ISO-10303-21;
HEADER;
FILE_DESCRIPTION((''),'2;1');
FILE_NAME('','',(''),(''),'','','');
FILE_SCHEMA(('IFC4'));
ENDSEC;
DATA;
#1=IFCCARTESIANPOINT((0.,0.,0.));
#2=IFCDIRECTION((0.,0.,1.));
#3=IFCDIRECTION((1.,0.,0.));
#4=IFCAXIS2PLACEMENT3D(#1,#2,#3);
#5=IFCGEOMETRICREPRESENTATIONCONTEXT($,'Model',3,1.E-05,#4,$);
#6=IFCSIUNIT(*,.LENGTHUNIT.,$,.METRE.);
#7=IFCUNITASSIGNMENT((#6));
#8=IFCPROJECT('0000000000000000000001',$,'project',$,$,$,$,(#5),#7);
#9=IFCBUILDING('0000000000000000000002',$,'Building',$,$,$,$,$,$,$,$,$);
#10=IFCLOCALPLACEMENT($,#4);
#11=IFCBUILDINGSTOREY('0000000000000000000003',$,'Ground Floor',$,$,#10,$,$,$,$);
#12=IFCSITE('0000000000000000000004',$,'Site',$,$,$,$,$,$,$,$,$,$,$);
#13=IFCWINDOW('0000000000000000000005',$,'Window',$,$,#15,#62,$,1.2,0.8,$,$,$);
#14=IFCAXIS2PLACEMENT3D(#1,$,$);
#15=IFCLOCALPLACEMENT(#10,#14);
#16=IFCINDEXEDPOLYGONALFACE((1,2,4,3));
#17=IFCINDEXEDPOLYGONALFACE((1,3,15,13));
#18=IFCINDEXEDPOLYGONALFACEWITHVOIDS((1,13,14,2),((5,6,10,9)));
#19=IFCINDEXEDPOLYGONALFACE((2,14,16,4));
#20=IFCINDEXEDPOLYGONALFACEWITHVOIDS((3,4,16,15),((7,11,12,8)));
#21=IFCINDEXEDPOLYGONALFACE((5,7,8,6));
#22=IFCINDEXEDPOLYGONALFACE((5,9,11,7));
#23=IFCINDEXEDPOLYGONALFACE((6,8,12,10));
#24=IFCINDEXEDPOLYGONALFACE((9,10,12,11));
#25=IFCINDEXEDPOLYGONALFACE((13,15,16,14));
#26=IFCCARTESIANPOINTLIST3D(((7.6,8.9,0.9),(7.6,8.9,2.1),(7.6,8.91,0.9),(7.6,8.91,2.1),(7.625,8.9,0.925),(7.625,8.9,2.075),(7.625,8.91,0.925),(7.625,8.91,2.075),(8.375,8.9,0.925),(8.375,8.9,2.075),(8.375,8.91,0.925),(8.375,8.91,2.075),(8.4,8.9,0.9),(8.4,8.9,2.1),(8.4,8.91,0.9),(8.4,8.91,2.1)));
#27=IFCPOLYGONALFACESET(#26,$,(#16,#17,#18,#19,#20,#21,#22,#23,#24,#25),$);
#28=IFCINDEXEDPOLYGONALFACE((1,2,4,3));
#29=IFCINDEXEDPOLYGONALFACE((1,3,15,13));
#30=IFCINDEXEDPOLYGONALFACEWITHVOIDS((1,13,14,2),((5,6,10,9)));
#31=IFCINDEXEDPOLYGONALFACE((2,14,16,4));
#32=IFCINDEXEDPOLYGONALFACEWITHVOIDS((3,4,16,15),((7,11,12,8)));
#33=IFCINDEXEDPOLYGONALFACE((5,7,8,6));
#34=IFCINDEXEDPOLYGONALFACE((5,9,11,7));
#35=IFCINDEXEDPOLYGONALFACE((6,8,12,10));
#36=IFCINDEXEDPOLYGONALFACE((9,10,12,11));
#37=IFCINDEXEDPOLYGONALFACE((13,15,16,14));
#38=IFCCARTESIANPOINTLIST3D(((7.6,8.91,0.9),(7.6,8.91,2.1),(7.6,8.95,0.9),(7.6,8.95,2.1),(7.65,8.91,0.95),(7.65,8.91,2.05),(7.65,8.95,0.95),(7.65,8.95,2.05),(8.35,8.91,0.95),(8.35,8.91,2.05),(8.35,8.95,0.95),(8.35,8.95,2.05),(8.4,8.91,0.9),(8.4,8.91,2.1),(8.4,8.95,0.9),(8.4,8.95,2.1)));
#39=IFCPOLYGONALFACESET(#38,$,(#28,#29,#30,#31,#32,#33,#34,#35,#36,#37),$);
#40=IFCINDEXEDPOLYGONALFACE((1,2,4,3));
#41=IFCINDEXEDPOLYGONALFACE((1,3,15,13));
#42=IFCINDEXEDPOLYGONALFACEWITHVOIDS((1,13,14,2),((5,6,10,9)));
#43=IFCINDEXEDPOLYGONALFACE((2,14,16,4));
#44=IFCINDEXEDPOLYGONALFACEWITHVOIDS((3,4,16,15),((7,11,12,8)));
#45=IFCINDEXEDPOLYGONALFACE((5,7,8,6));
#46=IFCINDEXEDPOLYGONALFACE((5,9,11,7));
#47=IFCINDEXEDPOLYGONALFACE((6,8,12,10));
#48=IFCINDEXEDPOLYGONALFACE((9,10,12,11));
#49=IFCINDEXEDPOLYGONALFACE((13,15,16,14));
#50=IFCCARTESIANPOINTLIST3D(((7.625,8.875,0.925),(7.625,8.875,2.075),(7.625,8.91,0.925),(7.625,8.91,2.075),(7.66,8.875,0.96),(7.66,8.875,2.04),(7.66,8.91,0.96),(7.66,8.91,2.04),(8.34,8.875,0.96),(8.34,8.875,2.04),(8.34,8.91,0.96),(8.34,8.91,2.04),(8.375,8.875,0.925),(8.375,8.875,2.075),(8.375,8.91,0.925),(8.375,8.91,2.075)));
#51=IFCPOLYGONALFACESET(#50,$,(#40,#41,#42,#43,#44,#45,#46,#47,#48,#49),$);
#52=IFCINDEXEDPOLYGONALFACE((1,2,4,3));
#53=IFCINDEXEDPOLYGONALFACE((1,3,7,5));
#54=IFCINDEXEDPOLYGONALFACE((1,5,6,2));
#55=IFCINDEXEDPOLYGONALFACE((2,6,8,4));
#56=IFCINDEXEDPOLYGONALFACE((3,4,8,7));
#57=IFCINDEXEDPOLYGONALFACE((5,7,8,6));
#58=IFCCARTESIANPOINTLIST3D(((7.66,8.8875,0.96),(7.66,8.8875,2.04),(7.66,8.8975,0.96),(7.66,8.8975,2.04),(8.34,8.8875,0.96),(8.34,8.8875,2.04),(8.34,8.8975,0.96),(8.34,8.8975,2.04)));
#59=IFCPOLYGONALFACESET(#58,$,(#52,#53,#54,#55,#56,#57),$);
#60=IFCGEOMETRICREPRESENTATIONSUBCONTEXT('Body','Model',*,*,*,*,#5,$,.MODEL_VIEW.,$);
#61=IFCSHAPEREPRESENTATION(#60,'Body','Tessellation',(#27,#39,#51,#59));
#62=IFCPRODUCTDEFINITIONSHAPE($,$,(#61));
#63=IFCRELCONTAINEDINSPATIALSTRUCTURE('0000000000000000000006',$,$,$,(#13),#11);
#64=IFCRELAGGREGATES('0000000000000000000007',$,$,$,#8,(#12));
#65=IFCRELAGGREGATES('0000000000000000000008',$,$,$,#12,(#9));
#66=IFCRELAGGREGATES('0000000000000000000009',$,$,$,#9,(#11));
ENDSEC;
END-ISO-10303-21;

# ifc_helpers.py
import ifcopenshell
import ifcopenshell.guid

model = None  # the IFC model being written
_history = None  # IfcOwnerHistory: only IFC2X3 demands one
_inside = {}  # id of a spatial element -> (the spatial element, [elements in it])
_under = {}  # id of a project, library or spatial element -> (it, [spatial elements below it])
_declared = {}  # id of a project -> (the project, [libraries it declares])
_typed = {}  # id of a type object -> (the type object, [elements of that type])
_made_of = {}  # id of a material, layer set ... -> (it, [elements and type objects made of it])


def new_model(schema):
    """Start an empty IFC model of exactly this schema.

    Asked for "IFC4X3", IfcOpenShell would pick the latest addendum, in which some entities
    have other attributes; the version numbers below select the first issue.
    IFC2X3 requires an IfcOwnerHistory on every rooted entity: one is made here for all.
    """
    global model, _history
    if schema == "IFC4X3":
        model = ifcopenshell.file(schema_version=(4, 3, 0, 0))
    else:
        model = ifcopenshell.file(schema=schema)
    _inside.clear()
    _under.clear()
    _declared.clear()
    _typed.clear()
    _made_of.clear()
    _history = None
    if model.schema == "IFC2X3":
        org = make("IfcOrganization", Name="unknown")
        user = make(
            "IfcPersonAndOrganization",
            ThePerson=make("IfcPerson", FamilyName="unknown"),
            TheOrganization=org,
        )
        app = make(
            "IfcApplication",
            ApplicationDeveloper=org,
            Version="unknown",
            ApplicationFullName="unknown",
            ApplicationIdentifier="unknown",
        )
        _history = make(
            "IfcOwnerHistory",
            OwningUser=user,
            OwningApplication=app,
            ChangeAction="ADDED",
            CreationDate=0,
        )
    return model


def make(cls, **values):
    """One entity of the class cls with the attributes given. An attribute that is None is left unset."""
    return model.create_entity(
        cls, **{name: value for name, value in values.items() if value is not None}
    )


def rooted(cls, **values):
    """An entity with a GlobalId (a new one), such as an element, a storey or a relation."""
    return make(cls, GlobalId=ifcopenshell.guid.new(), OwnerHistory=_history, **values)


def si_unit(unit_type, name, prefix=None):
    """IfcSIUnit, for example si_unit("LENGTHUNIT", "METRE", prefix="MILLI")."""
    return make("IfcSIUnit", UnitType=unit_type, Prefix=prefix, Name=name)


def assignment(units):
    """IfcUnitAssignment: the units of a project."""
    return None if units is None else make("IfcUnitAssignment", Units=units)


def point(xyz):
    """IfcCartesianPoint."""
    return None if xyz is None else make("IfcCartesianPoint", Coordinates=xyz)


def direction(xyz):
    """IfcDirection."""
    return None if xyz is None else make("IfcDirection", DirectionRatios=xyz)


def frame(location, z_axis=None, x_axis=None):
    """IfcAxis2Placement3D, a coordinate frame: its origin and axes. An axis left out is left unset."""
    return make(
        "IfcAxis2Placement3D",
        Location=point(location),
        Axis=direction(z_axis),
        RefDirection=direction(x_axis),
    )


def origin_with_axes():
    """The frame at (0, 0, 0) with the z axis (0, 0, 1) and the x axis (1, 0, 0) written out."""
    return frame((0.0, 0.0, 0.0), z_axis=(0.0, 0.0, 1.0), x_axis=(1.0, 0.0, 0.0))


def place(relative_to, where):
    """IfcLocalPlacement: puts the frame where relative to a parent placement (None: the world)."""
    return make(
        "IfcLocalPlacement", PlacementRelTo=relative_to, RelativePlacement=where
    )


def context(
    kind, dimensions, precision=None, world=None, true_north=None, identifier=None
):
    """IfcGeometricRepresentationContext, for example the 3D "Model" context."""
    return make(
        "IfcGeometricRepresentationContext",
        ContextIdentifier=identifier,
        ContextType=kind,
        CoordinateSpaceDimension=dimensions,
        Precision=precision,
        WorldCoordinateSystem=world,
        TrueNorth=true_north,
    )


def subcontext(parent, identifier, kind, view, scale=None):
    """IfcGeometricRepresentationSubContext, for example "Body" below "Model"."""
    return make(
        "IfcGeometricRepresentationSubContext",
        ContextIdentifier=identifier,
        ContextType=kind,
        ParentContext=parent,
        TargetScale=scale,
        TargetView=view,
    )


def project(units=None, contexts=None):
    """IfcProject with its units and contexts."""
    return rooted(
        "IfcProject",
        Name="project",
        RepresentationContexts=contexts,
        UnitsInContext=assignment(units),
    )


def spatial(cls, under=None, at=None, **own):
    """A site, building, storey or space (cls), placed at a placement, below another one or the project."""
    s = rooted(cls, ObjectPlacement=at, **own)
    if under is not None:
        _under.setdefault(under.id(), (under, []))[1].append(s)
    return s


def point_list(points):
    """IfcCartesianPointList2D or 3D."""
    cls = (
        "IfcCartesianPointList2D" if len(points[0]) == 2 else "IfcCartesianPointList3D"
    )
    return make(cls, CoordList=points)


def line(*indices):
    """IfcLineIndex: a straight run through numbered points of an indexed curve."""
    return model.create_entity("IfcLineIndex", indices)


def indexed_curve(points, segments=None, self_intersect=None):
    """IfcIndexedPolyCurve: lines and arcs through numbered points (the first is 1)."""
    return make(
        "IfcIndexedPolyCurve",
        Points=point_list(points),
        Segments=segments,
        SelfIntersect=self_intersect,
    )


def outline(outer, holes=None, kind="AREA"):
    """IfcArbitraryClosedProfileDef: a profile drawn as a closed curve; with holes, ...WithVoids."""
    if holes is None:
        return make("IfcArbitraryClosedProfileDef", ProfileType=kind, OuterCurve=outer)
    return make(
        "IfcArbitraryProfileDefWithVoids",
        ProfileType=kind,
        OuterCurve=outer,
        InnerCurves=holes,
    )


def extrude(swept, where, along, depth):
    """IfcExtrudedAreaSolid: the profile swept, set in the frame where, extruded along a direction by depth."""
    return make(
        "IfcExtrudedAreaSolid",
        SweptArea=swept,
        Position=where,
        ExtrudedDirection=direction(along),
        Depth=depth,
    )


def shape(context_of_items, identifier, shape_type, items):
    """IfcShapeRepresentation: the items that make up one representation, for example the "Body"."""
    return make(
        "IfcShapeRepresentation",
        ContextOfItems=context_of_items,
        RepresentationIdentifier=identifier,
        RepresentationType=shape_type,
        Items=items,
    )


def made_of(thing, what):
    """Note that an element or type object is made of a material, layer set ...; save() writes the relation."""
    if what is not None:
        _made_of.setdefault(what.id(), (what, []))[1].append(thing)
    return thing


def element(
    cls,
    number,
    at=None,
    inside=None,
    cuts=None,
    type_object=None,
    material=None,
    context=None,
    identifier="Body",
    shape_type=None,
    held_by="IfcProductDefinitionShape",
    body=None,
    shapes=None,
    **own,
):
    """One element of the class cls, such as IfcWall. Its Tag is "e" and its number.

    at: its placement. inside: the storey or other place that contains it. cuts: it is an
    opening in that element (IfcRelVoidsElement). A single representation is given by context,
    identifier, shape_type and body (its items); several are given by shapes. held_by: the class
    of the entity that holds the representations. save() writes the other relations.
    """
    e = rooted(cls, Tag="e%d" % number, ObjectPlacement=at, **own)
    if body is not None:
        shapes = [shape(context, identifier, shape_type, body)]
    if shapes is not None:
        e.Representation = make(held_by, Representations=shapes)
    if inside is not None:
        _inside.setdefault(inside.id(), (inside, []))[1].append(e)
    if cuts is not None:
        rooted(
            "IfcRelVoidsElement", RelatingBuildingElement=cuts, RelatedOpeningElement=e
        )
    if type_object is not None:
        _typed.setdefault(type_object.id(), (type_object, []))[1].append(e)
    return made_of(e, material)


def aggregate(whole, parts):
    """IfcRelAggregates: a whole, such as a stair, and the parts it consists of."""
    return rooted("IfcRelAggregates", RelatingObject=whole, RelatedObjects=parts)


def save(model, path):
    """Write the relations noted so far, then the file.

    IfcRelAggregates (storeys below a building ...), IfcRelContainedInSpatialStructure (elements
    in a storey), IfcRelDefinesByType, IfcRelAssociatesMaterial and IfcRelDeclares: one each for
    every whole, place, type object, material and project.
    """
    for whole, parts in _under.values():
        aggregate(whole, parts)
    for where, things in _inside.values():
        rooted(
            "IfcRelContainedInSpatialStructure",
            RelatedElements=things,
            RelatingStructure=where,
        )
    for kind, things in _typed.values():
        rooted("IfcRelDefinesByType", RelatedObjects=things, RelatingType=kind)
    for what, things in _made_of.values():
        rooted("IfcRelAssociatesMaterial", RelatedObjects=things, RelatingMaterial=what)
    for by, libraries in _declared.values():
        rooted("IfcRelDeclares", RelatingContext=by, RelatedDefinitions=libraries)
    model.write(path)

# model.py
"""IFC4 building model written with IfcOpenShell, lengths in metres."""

from ifc_helpers import new_model, si_unit, frame, origin_with_axes, place, context, subcontext, project, spatial, line, indexed_curve, outline, extrude, element, save


model = new_model("IFC4")

# Units and contexts
model_context = context("Model", 3, precision=1e-05, world=origin_with_axes())
body_context = subcontext(model_context, "Body", "Model", "MODEL_VIEW")
ifc_project = project(units=[si_unit("LENGTHUNIT", "METRE")], contexts=[model_context])

# Site, building, storey
site = spatial("IfcSite", under=ifc_project, Name="Site")
building = spatial("IfcBuilding", under=site, Name="Building")
storey_placement = place(None, origin_with_axes())
storey = spatial("IfcBuildingStorey", under=building, at=storey_placement, Name="Ground Floor")

# Window
window_1_placement = place(storey_placement, frame((8.4, 9.0, 0.9), z_axis=(0.0, 0.0, 1.0), x_axis=(-1.0, 0.0, 0.0)))
element("IfcWindow", 1, at=window_1_placement, inside=storey, Name="Window", OverallHeight=1.2, OverallWidth=0.8, context=body_context, shape_type="SweptSolid", body=[
    extrude(outline(indexed_curve([(0.0, 0.0), (0.8, 0.0), (0.8, 1.2), (0.0, 1.2)], segments=[line(1, 2, 3, 4, 1)]), holes=[indexed_curve([(0.025, 0.025), (0.775, 0.025), (0.775, 1.175), (0.025, 1.175)], segments=[line(1, 2, 3, 4, 1)])]), frame((0.0, 0.09, 0.0), z_axis=(0.0, -1.0, 0.0), x_axis=(1.0, 0.0, 0.0)), (0.0, 0.0, -1.0), 0.01),
    extrude(outline(indexed_curve([(0.0, 0.0), (0.8, 0.0), (0.8, 1.2), (0.0, 1.2)], segments=[line(1, 2, 3, 4, 1)]), holes=[indexed_curve([(0.05, 0.05), (0.75, 0.05), (0.75, 1.15), (0.05, 1.15)], segments=[line(1, 2, 3, 4, 1)])]), frame((0.0, 0.05, 0.0), z_axis=(0.0, -1.0, 0.0), x_axis=(1.0, 0.0, 0.0)), (0.0, 0.0, -1.0), 0.04),
    extrude(outline(indexed_curve([(0.0, 0.0), (0.75, 0.0), (0.75, 1.15), (0.0, 1.15)], segments=[line(1, 2, 3, 4, 1)]), holes=[indexed_curve([(0.035, 0.035), (0.715, 0.035), (0.715, 1.115), (0.035, 1.115)], segments=[line(1, 2, 3, 4, 1)])]), frame((0.025, 0.09, 0.025), z_axis=(0.0, -1.0, 0.0), x_axis=(1.0, 0.0, 0.0)), (0.0, 0.0, -1.0), 0.035),
    extrude(outline(indexed_curve([(0.035, 0.035), (0.715, 0.035), (0.715, 1.115), (0.035, 1.115)], segments=[line(1, 2, 3, 4, 1)])), frame((0.025, 0.1025, 0.025), z_axis=(0.0, -1.0, 0.0), x_axis=(1.0, 0.0, 0.0)), (0.0, 0.0, -1.0), 0.01),
])

save(model, "model.ifc")
